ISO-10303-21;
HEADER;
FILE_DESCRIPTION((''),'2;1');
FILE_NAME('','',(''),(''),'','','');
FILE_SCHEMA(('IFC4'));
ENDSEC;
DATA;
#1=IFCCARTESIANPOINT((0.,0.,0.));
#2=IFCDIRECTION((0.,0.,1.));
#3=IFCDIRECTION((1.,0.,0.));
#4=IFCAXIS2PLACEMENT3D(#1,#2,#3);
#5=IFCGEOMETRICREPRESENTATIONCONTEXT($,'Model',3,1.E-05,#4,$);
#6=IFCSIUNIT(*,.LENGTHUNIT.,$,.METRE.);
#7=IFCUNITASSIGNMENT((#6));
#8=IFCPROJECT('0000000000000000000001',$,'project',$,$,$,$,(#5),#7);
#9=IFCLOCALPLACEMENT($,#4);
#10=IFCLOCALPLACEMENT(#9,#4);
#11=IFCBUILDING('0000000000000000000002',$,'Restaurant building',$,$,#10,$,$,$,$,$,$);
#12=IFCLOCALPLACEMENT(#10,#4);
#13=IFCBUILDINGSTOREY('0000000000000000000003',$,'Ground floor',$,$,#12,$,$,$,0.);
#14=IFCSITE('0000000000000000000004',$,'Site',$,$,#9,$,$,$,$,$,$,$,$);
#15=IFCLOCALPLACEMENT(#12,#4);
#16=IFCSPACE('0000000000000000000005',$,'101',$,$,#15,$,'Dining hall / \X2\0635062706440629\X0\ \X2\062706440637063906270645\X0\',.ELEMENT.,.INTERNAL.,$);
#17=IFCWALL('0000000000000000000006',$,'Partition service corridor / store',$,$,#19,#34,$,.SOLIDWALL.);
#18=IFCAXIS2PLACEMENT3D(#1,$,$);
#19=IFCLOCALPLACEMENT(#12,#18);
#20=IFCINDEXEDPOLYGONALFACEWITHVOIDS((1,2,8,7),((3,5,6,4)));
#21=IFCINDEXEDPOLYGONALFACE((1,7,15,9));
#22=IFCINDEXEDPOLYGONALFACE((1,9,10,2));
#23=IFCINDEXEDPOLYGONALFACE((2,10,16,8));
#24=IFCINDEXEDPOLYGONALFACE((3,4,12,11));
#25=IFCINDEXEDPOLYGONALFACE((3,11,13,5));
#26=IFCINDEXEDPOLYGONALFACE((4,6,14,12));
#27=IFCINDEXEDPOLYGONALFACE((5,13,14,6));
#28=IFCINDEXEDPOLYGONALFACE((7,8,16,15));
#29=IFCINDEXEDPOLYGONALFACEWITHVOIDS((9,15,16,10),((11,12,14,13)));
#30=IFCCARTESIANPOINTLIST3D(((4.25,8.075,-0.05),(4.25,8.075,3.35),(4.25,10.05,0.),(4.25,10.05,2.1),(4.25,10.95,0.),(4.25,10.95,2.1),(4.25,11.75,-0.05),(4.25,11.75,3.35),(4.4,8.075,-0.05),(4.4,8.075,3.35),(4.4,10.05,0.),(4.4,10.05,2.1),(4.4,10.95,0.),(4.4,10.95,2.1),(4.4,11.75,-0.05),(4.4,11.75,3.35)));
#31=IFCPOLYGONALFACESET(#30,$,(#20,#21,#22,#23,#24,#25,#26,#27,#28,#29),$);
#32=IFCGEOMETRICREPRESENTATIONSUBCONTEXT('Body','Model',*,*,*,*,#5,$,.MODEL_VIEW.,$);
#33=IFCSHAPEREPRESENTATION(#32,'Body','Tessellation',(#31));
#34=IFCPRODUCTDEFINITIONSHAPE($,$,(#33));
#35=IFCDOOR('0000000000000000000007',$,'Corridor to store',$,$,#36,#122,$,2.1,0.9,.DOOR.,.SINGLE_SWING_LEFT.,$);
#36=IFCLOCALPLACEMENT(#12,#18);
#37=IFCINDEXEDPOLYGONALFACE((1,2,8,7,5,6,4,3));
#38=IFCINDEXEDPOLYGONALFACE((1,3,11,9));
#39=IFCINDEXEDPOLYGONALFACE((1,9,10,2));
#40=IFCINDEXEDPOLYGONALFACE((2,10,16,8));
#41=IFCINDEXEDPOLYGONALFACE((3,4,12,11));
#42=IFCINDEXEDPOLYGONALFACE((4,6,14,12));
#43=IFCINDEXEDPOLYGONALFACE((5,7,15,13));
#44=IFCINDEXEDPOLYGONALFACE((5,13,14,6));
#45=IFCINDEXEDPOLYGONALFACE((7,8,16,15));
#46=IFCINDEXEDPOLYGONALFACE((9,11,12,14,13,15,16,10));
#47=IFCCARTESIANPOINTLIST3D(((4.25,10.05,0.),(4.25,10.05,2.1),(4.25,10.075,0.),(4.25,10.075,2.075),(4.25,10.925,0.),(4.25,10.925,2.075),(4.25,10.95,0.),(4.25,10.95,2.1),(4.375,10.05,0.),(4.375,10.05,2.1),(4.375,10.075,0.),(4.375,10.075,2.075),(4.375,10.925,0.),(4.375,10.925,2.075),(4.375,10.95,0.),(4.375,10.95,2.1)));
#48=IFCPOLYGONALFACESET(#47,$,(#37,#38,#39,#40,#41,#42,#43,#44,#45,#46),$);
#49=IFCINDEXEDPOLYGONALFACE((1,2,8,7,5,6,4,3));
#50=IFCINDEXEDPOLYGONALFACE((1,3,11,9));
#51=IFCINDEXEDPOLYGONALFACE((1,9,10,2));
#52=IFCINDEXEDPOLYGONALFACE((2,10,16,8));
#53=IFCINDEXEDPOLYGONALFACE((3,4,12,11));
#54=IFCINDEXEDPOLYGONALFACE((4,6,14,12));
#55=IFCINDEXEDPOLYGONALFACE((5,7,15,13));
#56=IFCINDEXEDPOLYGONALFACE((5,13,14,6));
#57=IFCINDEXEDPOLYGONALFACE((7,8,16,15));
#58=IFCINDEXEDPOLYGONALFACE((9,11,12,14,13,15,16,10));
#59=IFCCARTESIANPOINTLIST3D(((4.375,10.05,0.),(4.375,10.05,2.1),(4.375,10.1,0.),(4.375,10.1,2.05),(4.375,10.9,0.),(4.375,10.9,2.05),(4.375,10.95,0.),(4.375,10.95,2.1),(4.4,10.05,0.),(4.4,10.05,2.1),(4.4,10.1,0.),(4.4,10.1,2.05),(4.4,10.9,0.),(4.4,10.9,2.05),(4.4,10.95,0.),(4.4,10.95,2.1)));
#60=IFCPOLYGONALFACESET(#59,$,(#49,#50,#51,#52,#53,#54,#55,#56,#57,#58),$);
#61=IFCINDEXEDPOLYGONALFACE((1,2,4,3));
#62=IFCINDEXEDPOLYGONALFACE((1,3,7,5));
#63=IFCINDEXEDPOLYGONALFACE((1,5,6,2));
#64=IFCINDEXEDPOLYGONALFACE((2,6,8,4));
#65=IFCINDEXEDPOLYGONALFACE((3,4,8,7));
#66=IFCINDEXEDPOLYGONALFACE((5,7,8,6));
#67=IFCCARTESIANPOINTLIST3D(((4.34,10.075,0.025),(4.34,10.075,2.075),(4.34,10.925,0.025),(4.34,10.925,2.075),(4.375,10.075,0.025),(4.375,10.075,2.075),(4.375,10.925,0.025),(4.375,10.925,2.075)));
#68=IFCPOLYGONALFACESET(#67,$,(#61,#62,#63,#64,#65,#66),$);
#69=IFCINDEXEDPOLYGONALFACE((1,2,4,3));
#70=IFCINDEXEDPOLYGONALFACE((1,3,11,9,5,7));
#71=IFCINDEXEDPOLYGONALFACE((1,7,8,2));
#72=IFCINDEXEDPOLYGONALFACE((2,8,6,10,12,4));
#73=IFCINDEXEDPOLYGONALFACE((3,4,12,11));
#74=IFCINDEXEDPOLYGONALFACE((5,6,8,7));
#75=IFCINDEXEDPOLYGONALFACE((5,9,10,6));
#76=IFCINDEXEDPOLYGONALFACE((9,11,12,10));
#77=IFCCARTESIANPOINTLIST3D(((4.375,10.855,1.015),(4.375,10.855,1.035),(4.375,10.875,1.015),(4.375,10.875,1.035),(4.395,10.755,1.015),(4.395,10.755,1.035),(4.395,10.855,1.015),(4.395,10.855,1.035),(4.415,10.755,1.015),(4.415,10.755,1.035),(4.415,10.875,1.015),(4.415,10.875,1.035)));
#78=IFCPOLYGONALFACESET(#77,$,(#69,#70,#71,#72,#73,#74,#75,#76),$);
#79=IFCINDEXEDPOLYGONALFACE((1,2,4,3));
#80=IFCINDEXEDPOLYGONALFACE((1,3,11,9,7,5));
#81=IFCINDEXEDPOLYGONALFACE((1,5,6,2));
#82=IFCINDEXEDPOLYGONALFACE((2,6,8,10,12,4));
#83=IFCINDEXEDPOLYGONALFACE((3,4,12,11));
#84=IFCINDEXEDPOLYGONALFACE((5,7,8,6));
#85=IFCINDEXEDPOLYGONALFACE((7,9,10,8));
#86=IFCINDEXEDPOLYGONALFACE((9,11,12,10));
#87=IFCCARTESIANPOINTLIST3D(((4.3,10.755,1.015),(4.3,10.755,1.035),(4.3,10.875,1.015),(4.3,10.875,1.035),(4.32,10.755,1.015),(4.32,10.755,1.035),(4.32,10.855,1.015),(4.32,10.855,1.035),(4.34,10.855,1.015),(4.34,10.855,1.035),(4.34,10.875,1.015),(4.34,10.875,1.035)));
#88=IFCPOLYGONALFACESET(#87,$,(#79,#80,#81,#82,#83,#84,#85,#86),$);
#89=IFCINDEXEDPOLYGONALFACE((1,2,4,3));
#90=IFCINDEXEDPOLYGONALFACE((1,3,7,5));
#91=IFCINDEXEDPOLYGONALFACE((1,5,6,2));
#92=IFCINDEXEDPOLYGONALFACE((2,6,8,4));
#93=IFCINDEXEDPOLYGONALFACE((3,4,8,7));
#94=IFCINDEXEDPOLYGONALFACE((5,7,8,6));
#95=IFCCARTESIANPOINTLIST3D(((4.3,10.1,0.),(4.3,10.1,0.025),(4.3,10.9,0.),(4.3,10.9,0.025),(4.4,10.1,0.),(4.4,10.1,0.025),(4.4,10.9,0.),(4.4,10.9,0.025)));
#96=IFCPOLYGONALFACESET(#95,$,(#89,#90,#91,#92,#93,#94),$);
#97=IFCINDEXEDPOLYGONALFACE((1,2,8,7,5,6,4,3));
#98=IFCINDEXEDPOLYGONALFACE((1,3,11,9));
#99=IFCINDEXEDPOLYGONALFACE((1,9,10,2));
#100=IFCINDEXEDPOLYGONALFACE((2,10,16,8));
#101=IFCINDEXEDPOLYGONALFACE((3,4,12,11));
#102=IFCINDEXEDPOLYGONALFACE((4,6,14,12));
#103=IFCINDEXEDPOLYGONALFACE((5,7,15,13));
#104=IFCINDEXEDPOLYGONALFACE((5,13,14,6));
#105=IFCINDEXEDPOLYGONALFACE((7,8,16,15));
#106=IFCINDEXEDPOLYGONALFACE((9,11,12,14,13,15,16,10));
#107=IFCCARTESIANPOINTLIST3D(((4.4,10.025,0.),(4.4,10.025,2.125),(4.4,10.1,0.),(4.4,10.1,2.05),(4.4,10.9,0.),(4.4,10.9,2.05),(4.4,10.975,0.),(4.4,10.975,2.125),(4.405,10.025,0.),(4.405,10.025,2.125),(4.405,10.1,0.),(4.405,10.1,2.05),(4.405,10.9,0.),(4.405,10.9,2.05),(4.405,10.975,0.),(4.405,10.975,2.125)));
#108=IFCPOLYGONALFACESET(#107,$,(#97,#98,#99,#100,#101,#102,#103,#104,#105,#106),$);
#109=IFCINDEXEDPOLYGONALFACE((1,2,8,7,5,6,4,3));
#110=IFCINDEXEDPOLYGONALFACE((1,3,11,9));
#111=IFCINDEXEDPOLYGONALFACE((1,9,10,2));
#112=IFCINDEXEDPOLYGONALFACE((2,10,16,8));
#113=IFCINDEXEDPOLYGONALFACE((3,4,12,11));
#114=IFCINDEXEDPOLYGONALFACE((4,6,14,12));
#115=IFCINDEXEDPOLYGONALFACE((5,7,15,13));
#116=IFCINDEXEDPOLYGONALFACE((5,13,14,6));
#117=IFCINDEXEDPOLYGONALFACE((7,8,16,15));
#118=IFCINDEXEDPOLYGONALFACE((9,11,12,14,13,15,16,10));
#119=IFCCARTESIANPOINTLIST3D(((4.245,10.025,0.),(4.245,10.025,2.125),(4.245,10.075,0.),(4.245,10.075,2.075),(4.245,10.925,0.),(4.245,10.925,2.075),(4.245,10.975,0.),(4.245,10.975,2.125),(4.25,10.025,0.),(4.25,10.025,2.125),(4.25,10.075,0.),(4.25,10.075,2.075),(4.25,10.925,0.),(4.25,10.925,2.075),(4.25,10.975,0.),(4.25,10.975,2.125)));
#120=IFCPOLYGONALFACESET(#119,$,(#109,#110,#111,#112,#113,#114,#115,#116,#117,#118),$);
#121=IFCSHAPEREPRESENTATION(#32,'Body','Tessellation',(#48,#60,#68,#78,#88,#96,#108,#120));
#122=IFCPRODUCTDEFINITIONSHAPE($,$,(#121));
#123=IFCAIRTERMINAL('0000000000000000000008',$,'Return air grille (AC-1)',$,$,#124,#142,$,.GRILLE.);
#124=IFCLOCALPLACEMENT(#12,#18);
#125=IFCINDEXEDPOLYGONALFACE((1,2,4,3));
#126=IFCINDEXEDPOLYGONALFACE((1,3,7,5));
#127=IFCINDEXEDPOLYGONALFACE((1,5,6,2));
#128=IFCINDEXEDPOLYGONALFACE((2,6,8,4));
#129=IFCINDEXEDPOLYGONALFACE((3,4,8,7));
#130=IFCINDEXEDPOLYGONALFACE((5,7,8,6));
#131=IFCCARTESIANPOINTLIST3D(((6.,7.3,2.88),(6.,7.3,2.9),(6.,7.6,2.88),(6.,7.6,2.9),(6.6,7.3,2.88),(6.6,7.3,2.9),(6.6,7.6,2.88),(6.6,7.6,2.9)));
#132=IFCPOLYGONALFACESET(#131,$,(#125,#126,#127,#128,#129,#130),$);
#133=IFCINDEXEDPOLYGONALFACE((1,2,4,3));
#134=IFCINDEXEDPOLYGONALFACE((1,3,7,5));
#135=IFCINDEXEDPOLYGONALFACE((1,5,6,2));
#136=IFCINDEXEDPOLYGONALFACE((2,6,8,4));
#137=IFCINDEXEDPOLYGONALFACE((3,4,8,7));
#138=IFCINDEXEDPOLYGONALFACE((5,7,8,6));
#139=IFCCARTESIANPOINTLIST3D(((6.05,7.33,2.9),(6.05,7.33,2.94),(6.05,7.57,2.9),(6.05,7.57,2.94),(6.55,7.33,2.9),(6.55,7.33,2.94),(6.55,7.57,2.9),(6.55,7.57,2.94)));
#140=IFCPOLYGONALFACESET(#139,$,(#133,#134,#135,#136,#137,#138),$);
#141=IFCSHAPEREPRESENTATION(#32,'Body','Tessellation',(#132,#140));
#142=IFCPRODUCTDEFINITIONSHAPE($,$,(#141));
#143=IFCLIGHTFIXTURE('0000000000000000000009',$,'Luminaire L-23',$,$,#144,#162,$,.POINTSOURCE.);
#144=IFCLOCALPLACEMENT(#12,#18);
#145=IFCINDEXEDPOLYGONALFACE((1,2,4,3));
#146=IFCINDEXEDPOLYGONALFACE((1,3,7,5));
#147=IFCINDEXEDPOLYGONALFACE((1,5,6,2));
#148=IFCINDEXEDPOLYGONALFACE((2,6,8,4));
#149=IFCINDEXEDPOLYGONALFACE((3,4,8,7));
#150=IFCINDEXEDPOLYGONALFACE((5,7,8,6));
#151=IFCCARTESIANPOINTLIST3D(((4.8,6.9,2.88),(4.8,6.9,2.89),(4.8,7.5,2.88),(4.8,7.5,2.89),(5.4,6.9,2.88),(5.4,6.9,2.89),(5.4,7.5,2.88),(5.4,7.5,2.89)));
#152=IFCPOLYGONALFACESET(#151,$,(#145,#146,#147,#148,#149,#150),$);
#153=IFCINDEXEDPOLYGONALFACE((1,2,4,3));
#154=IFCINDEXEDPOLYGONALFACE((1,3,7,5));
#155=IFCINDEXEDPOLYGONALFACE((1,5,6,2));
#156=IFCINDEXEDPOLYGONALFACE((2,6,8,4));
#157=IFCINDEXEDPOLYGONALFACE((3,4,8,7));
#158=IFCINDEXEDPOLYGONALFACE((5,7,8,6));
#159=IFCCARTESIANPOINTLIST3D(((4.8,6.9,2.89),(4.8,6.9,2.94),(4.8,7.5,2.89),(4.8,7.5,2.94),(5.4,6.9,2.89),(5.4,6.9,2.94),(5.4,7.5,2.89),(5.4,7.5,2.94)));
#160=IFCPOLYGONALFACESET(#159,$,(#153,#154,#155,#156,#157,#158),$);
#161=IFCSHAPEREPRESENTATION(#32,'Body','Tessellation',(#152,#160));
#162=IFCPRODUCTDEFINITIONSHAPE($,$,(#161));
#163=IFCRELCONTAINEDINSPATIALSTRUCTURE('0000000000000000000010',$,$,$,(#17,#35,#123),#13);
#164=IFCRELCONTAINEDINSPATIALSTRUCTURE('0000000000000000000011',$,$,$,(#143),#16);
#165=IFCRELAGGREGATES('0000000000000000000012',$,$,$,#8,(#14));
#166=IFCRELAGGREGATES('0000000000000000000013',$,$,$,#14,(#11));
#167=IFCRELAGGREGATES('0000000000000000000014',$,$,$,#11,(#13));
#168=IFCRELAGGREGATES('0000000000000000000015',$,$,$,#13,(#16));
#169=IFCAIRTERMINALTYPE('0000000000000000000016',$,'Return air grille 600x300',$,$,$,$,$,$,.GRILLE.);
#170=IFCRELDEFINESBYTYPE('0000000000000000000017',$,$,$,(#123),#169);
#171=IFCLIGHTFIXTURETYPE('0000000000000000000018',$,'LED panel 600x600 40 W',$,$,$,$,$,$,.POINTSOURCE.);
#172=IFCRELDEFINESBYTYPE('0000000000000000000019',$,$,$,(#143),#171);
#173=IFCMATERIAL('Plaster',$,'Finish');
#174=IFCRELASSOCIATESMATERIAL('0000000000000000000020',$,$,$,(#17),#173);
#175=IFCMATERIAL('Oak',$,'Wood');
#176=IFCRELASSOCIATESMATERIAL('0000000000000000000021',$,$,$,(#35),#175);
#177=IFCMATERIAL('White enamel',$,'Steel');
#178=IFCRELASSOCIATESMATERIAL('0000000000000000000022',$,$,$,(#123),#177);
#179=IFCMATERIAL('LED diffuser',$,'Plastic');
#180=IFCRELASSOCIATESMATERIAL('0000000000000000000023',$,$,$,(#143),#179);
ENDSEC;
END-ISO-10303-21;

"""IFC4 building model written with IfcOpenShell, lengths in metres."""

from ifc_helpers import new_model, si_unit, frame, origin, origin_with_axes, origin_2d, place, context, subcontext, project, spatial, line, indexed_curve, rectangle, outline, extrude, source, transform, mapped, material, type_object, type_shapes, element, fill, save


model = new_model("IFC4")

# Units and contexts
model_context = context("Model", 3, precision=1e-05, world=origin_with_axes())
body_context = subcontext(model_context, "Body", "Model", "MODEL_VIEW")
ifc_project = project(units=[si_unit("LENGTHUNIT", "METRE")], contexts=[model_context])

# Site, building, storey
site_placement = place(None, origin_with_axes())
site = spatial("IfcSite", under=ifc_project, at=site_placement, Name="Site")
building_placement = place(site_placement, origin_with_axes())
building = spatial("IfcBuilding", under=site, at=building_placement, Name="Restaurant building")
storey_placement = place(building_placement, origin_with_axes())
storey = spatial("IfcBuildingStorey", under=building, at=storey_placement, Name="Ground floor", Elevation=0.0)

# Wall, opening, door
ifc_material_1 = material(Name="Plaster", Category="Finish")
wall_placement = place(storey_placement, frame((4.325, 8.075, 0.0), z_axis=(0.0, 0.0, 1.0), x_axis=(0.0, 1.0, 0.0)))
wall = element("IfcWall", 1, at=wall_placement, inside=storey, material=ifc_material_1, Name="Partition service corridor / store", PredefinedType="SOLIDWALL", context=body_context, shape_type="SweptSolid", body=[
    extrude(rectangle(XDim=3.675, YDim=0.15, at=origin_2d()), frame((1.8375, 0.0, -0.05)), (0.0, 0.0, 1.0), 3.4),
])
opening_placement = place(wall_placement, frame((1.975, -0.075, 0.0), z_axis=(0.0, 0.0, 1.0), x_axis=(1.0, 0.0, 0.0)))
opening = element("IfcOpeningElement", 2, at=opening_placement, cuts=wall, PredefinedType="OPENING", context=body_context, shape_type="SweptSolid", body=[
    extrude(rectangle(XDim=0.9, YDim=0.25, at=origin_2d()), frame((0.45, 0.075, 0.0)), (0.0, 0.0, 1.0), 2.1),
])
ifc_material_2 = material(Name="Oak", Category="Wood")
door_placement = place(storey_placement, frame((4.4, 10.05, 0.0), z_axis=(0.0, 0.0, 1.0), x_axis=(0.0, 1.0, 0.0)))
door = element("IfcDoor", 3, at=door_placement, inside=storey, material=ifc_material_2, Name="Corridor to store", OperationType="SINGLE_SWING_LEFT", OverallHeight=2.1, OverallWidth=0.9, PredefinedType="DOOR", context=body_context, shape_type="SweptSolid", body=[
    extrude(outline(indexed_curve([(0.0, 0.0), (0.0, 2.1), (0.9, 2.1), (0.9, 0.0), (0.875, 0.0), (0.875, 2.075), (0.025, 2.075), (0.025, 0.0)], segments=[line(1, 2, 3, 4, 5, 6, 7, 8, 1)])), frame((0.0, 0.025, 0.0), z_axis=(0.0, -1.0, 0.0), x_axis=(1.0, 0.0, 0.0)), (0.0, 0.0, -1.0), 0.125),
    extrude(outline(indexed_curve([(0.0, 0.0), (0.0, 2.1), (0.9, 2.1), (0.9, 0.0), (0.85, 0.0), (0.85, 2.05), (0.05, 2.05), (0.05, 0.0)], segments=[line(1, 2, 3, 4, 5, 6, 7, 8, 1)])), frame((0.0, 0.0, 0.0), z_axis=(0.0, -1.0, 0.0), x_axis=(1.0, 0.0, 0.0)), (0.0, 0.0, -1.0), 0.025),
    extrude(outline(indexed_curve([(0.0, 0.0), (0.85, 0.0), (0.85, 0.035), (0.0, 0.035)], segments=[line(1, 2, 3, 4, 1)])), frame((0.025, 0.025, 0.025), z_axis=(0.0, 0.0, 1.0), x_axis=(1.0, 0.0, 0.0)), (0.0, 0.0, 1.0), 2.05),
    extrude(outline(indexed_curve([(0.0, 0.0), (0.0, -0.04), (-0.12, -0.04), (-0.12, -0.02), (-0.02, -0.02), (-0.02, 0.0)], segments=[line(1, 2, 3, 4, 5, 6, 1)])), frame((0.825, 0.025, 1.015), z_axis=(0.0, 0.0, 1.0), x_axis=(1.0, 0.0, 0.0)), (0.0, 0.0, 1.0), 0.02),
    extrude(outline(indexed_curve([(0.0, 0.0), (0.0, 0.04), (-0.12, 0.04), (-0.12, 0.02), (-0.02, 0.02), (-0.02, 0.0)], segments=[line(1, 2, 3, 4, 5, 6, 1)])), frame((0.825, 0.06, 1.015), z_axis=(0.0, 0.0, 1.0), x_axis=(1.0, 0.0, 0.0)), (0.0, 0.0, 1.0), 0.02),
    extrude(outline(indexed_curve([(0.0, 0.0), (0.8, 0.0), (0.8, 0.1), (0.0, 0.1)], segments=[line(1, 2, 3, 4, 1)])), frame((0.05, 0.0, 0.0), z_axis=(0.0, 0.0, 1.0), x_axis=(1.0, 0.0, 0.0)), (0.0, 0.0, 1.0), 0.025),
    extrude(outline(indexed_curve([(0.0, 0.0), (0.0, 2.125), (0.95, 2.125), (0.95, 0.0), (0.875, 0.0), (0.875, 2.05), (0.075, 2.05), (0.075, 0.0)], segments=[line(1, 2, 3, 4, 5, 6, 7, 8, 1)])), frame((-0.025, -0.005, 0.0), z_axis=(0.0, -1.0, 0.0), x_axis=(1.0, 0.0, 0.0)), (0.0, 0.0, -1.0), 0.005),
    extrude(outline(indexed_curve([(0.0, 0.0), (0.0, 2.125), (0.95, 2.125), (0.95, 0.0), (0.9, 0.0), (0.9, 2.075), (0.05, 2.075), (0.05, 0.0)], segments=[line(1, 2, 3, 4, 5, 6, 7, 8, 1)])), frame((-0.025, 0.15, 0.0), z_axis=(0.0, -1.0, 0.0), x_axis=(1.0, 0.0, 0.0)), (0.0, 0.0, -1.0), 0.005),
])
fill(opening, door)

# Air terminal
ifc_material_3 = material(Name="White enamel", Category="Steel")
air_terminal_type = type_object("IfcAirTerminalType", Name="Return air grille 600x300", PredefinedType="GRILLE")
shared_shape_1 = source(origin(), body_context, "Body", "SweptSolid", [
    extrude(rectangle(XDim=0.6, YDim=0.3, at=origin_2d()), frame((0.0, 0.0, -0.06)), (0.0, 0.0, 1.0), 0.02),
    extrude(rectangle(XDim=0.5, YDim=0.24, at=origin_2d()), frame((0.0, 0.0, -0.04)), (0.0, 0.0, 1.0), 0.04),
])
type_shapes(air_terminal_type, [shared_shape_1])
air_terminal_placement = place(storey_placement, frame((6.3, 7.45, 2.94)))
element("IfcAirTerminal", 4, at=air_terminal_placement, inside=storey, type_object=air_terminal_type, material=ifc_material_3, Name="Return air grille (AC-1)", PredefinedType="GRILLE", context=body_context, shape_type="MappedRepresentation", body=[
    mapped(shared_shape_1, transform((0.0, 0.0, 0.0))),
])

# Shared definitions
space_1_placement = place(storey_placement, origin_with_axes())
space_1 = spatial("IfcSpace", under=storey, at=space_1_placement, Name="101", LongName="Dining hall / صالة الطعام", CompositionType="ELEMENT", PredefinedType="INTERNAL")

# Light fixture
ifc_material_4 = material(Name="LED diffuser", Category="Plastic")
light_fixture_type_1 = type_object("IfcLightFixtureType", Name="LED panel 600x600 40 W", PredefinedType="POINTSOURCE")
shared_shape_2 = source(origin(), body_context, "Body", "SweptSolid", [
    extrude(rectangle(XDim=0.6, YDim=0.6, at=origin_2d()), frame((0.0, 0.0, -0.06)), (0.0, 0.0, 1.0), 0.01),
    extrude(rectangle(XDim=0.6, YDim=0.6, at=origin_2d()), frame((0.0, 0.0, -0.05)), (0.0, 0.0, 1.0), 0.05),
])
type_shapes(light_fixture_type_1, [shared_shape_2])
light_fixture_1_placement = place(storey_placement, frame((5.1, 7.2, 2.94)))
element("IfcLightFixture", 5, at=light_fixture_1_placement, inside=space_1, type_object=light_fixture_type_1, material=ifc_material_4, Name="Luminaire L-23", PredefinedType="POINTSOURCE", context=body_context, shape_type="MappedRepresentation", body=[
    mapped(shared_shape_2, transform((0.0, 0.0, 0.0))),
])

save(model, "model.ifc")
